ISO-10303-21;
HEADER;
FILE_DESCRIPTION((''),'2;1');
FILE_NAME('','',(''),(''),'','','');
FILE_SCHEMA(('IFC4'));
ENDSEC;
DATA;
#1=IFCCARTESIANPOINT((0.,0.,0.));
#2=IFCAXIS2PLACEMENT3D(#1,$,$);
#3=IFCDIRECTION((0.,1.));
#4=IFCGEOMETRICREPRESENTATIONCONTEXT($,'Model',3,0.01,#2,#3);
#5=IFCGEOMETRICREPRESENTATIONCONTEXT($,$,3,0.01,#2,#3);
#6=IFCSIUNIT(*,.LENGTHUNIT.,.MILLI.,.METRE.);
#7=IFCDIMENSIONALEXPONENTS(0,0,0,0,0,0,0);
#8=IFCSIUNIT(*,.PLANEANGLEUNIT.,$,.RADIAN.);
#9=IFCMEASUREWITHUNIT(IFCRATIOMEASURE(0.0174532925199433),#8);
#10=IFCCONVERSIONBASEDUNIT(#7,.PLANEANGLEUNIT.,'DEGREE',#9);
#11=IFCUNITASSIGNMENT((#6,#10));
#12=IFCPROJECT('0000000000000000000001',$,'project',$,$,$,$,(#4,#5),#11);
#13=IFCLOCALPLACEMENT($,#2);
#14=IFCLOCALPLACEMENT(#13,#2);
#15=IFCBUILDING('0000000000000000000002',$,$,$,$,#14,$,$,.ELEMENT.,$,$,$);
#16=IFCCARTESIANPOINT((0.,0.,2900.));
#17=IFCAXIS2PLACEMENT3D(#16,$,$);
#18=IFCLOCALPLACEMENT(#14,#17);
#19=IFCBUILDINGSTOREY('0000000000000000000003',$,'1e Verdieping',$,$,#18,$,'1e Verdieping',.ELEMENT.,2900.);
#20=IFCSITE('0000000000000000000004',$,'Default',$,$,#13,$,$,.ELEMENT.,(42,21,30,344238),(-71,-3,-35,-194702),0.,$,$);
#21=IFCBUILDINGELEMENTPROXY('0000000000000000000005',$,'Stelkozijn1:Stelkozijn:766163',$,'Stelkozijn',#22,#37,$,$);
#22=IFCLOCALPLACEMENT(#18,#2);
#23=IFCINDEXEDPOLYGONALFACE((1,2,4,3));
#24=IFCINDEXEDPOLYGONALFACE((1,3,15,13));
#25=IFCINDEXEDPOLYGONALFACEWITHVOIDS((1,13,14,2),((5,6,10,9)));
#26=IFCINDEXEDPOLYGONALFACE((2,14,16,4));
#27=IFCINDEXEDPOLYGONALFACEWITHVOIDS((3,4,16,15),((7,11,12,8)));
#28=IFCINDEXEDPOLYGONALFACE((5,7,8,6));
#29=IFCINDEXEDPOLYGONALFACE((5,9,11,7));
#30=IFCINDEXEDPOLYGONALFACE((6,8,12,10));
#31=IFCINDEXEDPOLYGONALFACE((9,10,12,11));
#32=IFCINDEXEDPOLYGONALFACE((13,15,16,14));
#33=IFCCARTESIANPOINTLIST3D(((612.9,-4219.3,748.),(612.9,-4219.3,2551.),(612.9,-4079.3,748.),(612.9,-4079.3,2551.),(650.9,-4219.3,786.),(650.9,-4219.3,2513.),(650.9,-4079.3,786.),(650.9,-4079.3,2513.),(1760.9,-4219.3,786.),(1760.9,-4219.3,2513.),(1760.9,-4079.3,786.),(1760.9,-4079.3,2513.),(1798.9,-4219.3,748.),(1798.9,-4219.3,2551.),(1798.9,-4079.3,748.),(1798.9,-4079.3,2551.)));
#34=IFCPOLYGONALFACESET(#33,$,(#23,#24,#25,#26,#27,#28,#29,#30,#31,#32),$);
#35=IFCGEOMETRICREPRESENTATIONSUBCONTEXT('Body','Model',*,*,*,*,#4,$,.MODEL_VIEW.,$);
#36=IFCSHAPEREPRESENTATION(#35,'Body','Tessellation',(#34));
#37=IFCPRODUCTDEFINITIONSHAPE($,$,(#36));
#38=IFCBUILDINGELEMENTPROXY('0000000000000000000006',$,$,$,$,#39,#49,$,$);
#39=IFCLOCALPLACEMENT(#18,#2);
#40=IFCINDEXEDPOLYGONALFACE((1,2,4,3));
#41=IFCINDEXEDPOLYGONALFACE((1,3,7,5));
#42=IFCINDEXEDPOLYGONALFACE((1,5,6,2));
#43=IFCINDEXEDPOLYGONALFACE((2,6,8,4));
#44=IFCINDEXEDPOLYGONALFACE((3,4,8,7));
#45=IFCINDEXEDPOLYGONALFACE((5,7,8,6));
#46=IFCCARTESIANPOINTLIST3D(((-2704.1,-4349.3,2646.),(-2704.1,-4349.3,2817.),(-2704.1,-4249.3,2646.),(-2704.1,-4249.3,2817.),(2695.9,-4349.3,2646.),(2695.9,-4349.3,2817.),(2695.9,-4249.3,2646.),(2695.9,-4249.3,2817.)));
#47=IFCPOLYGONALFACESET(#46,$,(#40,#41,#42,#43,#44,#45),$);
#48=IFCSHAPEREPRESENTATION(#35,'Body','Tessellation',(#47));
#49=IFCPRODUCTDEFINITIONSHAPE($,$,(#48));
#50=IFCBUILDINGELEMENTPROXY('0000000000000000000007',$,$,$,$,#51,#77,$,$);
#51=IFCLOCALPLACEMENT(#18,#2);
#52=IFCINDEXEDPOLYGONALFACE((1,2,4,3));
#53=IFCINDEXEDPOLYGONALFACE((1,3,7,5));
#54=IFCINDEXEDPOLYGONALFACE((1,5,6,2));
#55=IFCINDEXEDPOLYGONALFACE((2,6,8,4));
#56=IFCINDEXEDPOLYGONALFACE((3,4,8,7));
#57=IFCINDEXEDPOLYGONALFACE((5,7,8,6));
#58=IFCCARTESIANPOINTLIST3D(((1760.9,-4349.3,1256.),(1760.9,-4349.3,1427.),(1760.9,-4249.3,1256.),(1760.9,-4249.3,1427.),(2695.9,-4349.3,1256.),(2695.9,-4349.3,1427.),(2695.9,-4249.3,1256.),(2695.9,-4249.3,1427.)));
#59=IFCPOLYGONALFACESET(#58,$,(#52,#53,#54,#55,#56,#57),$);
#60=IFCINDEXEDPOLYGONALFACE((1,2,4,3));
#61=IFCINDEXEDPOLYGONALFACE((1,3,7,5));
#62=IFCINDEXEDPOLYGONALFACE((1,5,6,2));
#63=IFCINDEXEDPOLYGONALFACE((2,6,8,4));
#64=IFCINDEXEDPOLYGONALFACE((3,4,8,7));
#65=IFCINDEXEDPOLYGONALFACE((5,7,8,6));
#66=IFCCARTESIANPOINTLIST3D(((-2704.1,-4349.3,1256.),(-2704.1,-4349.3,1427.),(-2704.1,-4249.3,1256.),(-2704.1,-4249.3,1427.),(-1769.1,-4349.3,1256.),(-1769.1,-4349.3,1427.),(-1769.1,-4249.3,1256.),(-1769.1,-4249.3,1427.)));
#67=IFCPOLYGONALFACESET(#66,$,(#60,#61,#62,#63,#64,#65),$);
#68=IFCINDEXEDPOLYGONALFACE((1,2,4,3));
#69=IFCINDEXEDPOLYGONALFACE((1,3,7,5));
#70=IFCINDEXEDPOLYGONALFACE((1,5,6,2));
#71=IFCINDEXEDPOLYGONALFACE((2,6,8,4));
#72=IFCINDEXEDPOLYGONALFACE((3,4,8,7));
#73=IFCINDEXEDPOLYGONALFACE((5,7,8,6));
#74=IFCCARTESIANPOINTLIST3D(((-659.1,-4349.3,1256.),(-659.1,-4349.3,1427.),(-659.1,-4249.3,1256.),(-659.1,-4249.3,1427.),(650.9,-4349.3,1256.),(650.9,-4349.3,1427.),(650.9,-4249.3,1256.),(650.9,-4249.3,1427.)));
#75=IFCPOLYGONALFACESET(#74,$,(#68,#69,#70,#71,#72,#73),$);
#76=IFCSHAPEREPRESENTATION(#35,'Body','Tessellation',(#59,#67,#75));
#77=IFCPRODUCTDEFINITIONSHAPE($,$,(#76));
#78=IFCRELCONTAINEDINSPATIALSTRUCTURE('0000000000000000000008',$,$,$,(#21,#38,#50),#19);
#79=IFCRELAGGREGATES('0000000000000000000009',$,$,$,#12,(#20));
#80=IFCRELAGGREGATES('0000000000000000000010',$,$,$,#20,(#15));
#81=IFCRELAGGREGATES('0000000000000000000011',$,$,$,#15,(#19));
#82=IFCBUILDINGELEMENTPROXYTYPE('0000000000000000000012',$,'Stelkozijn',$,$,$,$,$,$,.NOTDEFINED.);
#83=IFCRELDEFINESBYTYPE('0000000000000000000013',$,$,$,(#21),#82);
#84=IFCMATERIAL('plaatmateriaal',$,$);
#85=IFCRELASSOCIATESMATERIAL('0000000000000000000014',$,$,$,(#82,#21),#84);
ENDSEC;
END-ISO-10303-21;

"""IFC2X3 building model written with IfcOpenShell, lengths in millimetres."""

from ifc_helpers import new_model, entity, si_unit, converted_unit, direction, frame, frame_2d, origin, origin_2d_with_axis, place, context, subcontext, project, spatial, polyline, rectangle, outline, extrude, source, transform, mapped, material, type_object, type_shapes, element, save


model = new_model("IFC2X3")

# Units and contexts
model_context = context("Model", 3, precision=0.01, world=origin(), true_north=direction((0.0, 1.0)))
context_of_model = context(None, 3, precision=0.01, world=origin(), true_north=direction((0.0, 1.0)))
body_context = subcontext(model_context, "Body", "Model", "MODEL_VIEW")
ifc_project = project(units=[si_unit("LENGTHUNIT", "METRE", prefix="MILLI"), converted_unit("PLANEANGLEUNIT", "DEGREE", entity("IfcRatioMeasure", 0.0174532925199433), si_unit("PLANEANGLEUNIT", "RADIAN"), dimensions=[0, 0, 0, 0, 0, 0, 0])], contexts=[model_context, context_of_model])

# Site, building, storey
site_placement = place(None, origin())
site = spatial("IfcSite", under=ifc_project, at=site_placement, Name="Default", CompositionType="ELEMENT", RefLatitude=(42, 21, 30, 344238), RefLongitude=(-71, -3, -35, -194702), RefElevation=0.0)
building_placement = place(site_placement, origin())
building = spatial("IfcBuilding", under=site, at=building_placement, CompositionType="ELEMENT")
storey_placement = place(building_placement, frame((0.0, 0.0, 2900.0)))
storey = spatial("IfcBuildingStorey", under=building, at=storey_placement, Name="1e Verdieping", LongName="1e Verdieping", CompositionType="ELEMENT", Elevation=2900.0)

# Building element proxies
ifc_material_1 = material(Name="plaatmateriaal")
building_element_proxy_type_1 = type_object("IfcBuildingElementProxyType", Name="Stelkozijn", PredefinedType="NOTDEFINED", material=ifc_material_1)
shared_shape_1 = source(origin(), body_context, "Body", "SweptSolid", [
    extrude(outline(polyline([(-593.0, -901.5), (593.0, -901.5), (593.0, 901.5), (-593.0, 901.5), (-593.0, -901.5)]), holes=[polyline([(555.0, -863.5), (-555.0, -863.5), (-555.0, 863.5), (555.0, 863.5), (555.0, -863.5)])]), frame((593.0, 0.0, 901.5), z_axis=(0.0, 1.0, 0.0), x_axis=(1.0, 0.0, 0.0)), (0.0, 0.0, 1.0), 140.0),
])
type_shapes(building_element_proxy_type_1, [shared_shape_1])
proxy_1_placement = place(storey_placement, frame((612.9, -4219.3, 748.0)))
element("IfcBuildingElementProxy", 1, at=proxy_1_placement, inside=storey, type_object=building_element_proxy_type_1, material=ifc_material_1, Name="Stelkozijn1:Stelkozijn:766163", ObjectType="Stelkozijn", context=body_context, shape_type="MappedRepresentation", body=[
    mapped(shared_shape_1, transform((0.0, 0.0, 0.0), scale=1.0)),
])
proxy_2_placement = place(storey_placement, frame((-2704.1, -4349.3, 2646.0)))
element("IfcBuildingElementProxy", 2, at=proxy_2_placement, inside=storey, context=body_context, shape_type="SweptSolid", body=[
    extrude(rectangle(XDim=5400.0, YDim=100.0, at=frame_2d((0.0, 0.0), x_axis=(1.0, 0.0))), frame((2700.0, 50.0, 0.0), z_axis=(0.0, 0.0, 1.0), x_axis=(-1.0, 0.0, 0.0)), (0.0, 0.0, 1.0), 171.0),
])
proxy_3_placement = place(storey_placement, frame((-2704.1, -4349.3, 1256.0)))
element("IfcBuildingElementProxy", 3, at=proxy_3_placement, inside=storey, context=body_context, shape_type="SweptSolid", body=[
    extrude(rectangle(XDim=935.0, YDim=100.0, at=frame_2d((0.0, 0.0), x_axis=(1.0, 0.0))), frame((4932.5, 50.0, 0.0), z_axis=(0.0, 0.0, 1.0), x_axis=(-1.0, 0.0, 0.0)), (0.0, 0.0, 1.0), 171.0),
    extrude(rectangle(XDim=935.0, YDim=100.0, at=frame_2d((0.0, 0.0), x_axis=(1.0, 0.0))), frame((467.5, 50.0, 0.0)), (0.0, 0.0, 1.0), 171.0),
    extrude(rectangle(XDim=1310.0, YDim=100.0, at=origin_2d_with_axis()), frame((2700.0, 50.0, 0.0)), (0.0, 0.0, 1.0), 171.0),
])

save(model, "model.ifc")
